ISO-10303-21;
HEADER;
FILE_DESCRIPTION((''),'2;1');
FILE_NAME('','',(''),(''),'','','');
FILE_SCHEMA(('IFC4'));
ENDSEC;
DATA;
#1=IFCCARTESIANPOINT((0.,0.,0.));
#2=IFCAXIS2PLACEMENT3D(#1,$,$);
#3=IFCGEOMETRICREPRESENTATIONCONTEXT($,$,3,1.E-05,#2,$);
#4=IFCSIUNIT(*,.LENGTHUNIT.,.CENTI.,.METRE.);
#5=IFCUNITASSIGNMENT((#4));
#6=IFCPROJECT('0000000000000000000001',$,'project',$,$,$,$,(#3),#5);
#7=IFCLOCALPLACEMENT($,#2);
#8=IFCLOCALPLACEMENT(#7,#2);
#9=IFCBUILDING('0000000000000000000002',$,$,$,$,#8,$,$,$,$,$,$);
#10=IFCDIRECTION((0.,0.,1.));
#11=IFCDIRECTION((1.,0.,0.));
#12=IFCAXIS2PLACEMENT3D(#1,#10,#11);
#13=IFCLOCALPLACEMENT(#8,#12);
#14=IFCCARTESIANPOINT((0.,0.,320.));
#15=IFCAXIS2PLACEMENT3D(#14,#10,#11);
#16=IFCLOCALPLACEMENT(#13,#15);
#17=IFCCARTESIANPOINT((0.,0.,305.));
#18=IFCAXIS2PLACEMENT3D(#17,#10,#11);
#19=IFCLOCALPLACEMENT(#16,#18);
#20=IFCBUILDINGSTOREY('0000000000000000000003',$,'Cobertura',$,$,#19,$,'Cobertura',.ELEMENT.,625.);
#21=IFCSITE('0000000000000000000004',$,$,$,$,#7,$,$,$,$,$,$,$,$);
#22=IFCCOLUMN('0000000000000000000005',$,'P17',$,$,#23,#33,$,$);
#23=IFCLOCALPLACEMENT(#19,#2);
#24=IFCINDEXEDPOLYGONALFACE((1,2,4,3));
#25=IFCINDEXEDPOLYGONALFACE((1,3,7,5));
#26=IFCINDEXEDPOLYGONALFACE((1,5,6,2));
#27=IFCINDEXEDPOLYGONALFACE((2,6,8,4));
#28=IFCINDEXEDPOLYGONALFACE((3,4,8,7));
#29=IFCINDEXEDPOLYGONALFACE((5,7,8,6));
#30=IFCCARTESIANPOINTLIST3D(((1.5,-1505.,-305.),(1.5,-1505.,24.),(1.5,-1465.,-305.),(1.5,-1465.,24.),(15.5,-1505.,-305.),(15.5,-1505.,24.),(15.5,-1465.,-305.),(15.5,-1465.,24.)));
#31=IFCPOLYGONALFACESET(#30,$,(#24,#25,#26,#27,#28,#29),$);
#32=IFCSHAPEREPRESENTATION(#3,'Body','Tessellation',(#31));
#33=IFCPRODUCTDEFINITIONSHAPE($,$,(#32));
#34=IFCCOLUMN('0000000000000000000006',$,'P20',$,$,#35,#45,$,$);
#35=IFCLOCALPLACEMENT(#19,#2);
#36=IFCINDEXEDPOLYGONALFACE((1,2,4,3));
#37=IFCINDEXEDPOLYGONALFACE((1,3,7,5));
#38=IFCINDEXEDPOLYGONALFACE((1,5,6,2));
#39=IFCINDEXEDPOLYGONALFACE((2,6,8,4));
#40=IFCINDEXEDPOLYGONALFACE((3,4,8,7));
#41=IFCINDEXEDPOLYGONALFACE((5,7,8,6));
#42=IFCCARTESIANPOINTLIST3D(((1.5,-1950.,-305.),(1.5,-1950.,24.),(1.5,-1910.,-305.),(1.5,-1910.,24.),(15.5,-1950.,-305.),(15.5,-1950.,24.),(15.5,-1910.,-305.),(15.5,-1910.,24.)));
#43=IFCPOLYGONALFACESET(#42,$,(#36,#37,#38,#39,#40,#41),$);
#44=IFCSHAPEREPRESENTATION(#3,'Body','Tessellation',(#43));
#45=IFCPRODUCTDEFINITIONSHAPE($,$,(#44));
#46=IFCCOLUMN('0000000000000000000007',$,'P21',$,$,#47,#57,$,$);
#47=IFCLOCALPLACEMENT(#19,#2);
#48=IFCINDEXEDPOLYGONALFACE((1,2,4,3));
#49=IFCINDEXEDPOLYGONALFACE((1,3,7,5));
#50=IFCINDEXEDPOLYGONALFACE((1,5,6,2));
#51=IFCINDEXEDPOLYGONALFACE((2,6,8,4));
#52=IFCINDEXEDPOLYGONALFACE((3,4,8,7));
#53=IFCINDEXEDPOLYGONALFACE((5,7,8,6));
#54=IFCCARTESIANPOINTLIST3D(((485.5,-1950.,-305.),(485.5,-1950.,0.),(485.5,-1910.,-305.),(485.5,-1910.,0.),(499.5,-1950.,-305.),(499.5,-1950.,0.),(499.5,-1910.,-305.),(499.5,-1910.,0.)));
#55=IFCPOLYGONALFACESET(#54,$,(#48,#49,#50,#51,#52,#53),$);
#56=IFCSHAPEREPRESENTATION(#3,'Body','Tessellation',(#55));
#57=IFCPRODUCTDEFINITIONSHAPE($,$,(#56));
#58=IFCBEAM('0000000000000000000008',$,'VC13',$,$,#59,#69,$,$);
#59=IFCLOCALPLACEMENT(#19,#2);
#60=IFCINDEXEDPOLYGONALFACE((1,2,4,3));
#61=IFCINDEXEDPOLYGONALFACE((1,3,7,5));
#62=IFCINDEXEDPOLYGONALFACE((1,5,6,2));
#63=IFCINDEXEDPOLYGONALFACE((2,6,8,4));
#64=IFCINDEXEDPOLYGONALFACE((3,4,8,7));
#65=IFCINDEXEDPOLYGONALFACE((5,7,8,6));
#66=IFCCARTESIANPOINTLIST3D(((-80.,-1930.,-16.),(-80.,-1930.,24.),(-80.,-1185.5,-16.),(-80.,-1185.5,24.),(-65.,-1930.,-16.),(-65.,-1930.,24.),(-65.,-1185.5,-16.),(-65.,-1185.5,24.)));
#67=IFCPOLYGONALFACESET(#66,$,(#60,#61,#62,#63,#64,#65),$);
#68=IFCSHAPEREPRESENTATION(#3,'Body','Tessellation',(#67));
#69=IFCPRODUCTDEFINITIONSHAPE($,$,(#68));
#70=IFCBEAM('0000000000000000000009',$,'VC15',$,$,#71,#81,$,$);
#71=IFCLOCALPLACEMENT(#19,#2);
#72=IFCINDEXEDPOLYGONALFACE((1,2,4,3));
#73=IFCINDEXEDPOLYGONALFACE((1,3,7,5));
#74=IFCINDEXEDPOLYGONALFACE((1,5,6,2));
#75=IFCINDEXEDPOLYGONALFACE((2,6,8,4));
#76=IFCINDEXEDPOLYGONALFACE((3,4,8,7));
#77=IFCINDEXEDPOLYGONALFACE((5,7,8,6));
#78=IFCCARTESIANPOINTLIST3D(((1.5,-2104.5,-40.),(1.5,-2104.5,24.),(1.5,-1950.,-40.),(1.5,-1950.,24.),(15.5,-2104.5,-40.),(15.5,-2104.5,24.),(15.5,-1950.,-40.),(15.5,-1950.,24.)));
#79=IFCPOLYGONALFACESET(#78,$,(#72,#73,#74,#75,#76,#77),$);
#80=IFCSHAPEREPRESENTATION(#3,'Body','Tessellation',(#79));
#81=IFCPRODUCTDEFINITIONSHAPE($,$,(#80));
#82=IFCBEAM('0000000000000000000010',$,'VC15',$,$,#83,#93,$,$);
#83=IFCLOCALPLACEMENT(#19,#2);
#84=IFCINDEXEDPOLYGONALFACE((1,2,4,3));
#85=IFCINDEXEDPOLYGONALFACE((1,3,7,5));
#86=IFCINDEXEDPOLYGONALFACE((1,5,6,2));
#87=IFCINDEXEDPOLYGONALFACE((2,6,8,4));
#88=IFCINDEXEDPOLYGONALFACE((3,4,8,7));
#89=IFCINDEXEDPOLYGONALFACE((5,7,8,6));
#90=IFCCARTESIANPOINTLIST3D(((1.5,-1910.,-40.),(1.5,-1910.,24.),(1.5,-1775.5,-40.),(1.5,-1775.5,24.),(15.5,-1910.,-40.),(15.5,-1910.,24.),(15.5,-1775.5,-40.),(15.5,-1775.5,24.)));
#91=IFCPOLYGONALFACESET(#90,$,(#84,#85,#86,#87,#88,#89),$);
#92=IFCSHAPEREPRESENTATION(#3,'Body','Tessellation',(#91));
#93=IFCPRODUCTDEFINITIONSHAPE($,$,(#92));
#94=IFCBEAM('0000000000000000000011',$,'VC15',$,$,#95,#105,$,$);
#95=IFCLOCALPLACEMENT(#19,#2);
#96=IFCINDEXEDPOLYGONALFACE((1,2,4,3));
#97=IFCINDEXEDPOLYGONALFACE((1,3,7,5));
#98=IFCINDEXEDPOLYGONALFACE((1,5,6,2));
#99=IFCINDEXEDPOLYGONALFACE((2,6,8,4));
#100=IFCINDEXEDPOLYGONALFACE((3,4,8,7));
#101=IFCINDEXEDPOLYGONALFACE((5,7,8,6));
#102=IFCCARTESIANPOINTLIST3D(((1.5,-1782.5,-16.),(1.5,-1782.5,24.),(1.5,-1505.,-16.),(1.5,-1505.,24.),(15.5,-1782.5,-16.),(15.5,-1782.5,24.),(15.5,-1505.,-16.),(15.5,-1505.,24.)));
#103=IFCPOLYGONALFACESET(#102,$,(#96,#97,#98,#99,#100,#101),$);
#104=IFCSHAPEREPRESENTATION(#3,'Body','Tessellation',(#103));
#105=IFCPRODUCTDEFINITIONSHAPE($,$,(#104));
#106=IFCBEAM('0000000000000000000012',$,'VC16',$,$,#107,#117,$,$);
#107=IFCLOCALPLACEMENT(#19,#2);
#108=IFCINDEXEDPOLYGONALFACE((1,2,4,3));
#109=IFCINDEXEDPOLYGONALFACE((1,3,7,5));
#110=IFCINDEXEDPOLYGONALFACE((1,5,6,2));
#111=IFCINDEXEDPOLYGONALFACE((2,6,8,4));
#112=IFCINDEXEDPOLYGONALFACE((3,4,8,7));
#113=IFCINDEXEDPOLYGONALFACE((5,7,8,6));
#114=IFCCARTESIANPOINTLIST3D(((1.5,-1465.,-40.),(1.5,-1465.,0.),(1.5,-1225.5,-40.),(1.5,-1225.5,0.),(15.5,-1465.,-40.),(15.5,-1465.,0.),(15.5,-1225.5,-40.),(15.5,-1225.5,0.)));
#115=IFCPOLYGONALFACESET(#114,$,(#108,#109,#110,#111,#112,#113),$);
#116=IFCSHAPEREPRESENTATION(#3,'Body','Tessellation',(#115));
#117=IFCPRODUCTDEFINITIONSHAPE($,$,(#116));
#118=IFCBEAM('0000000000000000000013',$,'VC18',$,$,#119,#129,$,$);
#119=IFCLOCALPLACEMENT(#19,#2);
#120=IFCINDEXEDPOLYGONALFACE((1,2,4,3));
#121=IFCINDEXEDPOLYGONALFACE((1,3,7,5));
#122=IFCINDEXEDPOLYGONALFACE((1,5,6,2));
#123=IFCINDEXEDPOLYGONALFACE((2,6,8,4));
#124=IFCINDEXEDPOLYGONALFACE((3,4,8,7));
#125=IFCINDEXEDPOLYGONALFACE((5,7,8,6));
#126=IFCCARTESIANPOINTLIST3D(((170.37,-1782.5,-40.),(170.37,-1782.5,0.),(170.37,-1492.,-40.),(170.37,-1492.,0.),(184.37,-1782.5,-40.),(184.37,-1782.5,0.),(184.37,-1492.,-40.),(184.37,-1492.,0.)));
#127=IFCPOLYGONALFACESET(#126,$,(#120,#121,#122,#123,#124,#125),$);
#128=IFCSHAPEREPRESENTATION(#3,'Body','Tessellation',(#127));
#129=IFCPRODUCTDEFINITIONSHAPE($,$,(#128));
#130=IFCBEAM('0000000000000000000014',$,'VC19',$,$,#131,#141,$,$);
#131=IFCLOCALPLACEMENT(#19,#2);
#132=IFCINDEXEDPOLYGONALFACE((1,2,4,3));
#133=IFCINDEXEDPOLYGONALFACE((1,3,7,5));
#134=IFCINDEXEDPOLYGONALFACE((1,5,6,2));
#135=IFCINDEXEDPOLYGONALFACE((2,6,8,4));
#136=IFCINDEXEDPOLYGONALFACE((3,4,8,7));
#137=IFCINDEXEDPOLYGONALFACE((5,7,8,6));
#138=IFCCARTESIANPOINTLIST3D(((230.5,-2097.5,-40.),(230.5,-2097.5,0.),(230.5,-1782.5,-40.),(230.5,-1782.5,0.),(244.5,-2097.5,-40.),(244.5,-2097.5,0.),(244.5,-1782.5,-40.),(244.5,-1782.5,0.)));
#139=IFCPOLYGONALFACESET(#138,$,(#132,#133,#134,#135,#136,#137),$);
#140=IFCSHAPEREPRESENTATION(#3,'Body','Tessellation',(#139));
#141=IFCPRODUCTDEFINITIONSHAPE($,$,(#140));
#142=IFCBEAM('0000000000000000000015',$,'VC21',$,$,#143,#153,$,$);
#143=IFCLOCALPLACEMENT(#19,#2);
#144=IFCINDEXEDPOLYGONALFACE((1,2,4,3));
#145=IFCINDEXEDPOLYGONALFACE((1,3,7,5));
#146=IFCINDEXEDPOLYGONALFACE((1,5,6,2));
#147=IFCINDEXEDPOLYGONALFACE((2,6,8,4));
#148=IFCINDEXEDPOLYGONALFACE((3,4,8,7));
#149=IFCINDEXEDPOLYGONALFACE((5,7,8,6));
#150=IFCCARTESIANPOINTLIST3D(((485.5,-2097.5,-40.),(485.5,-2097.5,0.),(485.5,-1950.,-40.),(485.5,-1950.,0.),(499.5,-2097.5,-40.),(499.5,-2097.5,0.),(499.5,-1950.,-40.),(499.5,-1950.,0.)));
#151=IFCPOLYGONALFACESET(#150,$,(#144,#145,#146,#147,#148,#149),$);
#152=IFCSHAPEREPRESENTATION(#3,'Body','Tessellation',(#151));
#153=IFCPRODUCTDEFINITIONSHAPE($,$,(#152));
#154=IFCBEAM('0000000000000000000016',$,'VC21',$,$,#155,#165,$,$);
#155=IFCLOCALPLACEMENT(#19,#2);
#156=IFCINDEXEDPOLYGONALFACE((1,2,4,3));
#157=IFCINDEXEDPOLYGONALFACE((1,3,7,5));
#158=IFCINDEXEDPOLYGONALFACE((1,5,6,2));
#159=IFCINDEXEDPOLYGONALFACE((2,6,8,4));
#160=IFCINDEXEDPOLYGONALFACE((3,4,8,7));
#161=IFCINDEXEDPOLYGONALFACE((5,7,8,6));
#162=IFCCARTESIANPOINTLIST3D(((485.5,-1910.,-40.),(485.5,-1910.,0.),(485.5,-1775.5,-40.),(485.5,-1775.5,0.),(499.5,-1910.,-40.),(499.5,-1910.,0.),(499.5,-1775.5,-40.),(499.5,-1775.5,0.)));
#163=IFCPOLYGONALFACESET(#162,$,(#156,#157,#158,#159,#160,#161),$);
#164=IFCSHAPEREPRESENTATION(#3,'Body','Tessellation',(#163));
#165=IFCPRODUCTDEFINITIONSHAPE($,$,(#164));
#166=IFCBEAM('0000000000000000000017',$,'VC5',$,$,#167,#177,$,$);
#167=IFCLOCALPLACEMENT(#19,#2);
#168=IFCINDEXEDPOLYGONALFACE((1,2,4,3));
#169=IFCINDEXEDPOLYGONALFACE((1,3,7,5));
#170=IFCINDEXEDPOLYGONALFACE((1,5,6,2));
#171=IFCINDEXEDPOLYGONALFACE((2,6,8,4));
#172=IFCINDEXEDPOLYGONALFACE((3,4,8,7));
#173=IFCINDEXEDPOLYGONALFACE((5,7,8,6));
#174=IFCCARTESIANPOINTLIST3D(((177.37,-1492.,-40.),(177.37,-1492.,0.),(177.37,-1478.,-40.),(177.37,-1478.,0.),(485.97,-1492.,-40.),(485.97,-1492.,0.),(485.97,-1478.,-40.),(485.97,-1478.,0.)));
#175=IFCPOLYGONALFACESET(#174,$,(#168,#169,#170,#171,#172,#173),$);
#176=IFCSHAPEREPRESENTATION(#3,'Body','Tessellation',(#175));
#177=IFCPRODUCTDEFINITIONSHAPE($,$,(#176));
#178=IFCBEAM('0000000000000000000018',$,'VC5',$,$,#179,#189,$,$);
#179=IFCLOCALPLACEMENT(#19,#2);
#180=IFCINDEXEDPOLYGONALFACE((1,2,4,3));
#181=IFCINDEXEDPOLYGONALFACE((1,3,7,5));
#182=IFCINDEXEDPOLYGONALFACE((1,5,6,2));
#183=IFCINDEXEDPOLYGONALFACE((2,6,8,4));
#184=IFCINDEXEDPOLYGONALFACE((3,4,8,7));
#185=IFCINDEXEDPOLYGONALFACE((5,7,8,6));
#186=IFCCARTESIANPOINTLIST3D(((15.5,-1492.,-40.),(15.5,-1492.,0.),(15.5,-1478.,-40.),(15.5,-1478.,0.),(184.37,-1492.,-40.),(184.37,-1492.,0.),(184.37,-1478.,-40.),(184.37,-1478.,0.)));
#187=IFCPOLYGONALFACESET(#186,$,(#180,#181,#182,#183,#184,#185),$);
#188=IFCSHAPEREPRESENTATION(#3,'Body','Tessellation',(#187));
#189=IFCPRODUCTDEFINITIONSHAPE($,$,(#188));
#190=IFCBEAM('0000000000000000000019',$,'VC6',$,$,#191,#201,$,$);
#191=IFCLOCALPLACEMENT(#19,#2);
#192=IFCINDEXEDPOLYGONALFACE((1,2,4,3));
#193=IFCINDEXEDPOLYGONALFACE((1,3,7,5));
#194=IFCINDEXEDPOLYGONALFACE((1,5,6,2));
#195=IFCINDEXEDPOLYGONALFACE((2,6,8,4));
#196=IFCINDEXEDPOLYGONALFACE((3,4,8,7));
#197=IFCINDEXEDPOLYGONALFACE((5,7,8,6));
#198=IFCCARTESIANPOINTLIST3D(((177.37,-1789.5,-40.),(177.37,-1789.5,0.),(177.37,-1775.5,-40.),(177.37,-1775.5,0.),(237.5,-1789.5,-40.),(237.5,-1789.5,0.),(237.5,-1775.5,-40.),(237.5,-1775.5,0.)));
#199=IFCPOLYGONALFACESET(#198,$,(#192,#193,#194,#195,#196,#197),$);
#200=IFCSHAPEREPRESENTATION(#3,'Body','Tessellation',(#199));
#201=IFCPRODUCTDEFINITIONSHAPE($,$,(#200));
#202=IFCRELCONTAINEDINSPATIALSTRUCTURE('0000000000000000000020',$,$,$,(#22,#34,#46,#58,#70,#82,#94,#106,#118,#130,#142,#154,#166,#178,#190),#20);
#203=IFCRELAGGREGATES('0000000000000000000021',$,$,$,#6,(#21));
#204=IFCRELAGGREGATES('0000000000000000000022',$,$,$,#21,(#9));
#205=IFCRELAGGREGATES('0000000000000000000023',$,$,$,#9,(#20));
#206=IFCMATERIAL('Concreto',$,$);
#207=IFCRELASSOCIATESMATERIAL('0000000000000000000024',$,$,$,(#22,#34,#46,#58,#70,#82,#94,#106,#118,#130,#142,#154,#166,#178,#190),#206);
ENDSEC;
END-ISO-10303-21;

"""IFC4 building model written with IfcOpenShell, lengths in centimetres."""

from ifc_helpers import new_model, si_unit, frame, origin, origin_with_axes, place, context, project, spatial, polyline, outline, extrude, material, element, save


model = new_model("IFC4")

# Units and contexts
context_of_model = context(None, 3, precision=1e-05, world=origin())
ifc_project = project(units=[si_unit("LENGTHUNIT", "METRE", prefix="CENTI")], contexts=[context_of_model])

# Site, building, storey
site_placement = place(None, origin())
site = spatial("IfcSite", under=ifc_project, at=site_placement)
building_placement = place(site_placement, origin())
building = spatial("IfcBuilding", under=site, at=building_placement)
placement_1 = place(building_placement, origin_with_axes())
placement_2 = place(placement_1, frame((0.0, 0.0, 320.0), z_axis=(0.0, 0.0, 1.0), x_axis=(1.0, 0.0, 0.0)))
storey_placement = place(placement_2, frame((0.0, 0.0, 305.0), z_axis=(0.0, 0.0, 1.0), x_axis=(1.0, 0.0, 0.0)))
storey = spatial("IfcBuildingStorey", under=building, at=storey_placement, Name="Cobertura", LongName="Cobertura", CompositionType="ELEMENT", Elevation=625.0)

# Columns
ifc_material = material(Name="Concreto")
for number, where, z_axis, x_axis, name in (
    (1, (8.5, -1485.0, 24.0), (0.0, 0.0, 1.0), (1.0, 0.0, 0.0), "P17"),
    (2, (8.5, -1930.0, 24.0), (0.0, 0.0, 1.0), (1.0, 0.0, 0.0), "P20"),
):
    element("IfcColumn", number, at=place(storey_placement, frame(where, z_axis=z_axis, x_axis=x_axis)), inside=storey, material=ifc_material, Name=name, context=context_of_model, shape_type="SolidModel", body=[
        extrude(outline(polyline([(-7.0, -20.0), (7.0, -20.0), (7.0, 20.0), (-7.0, 20.0), (-7.0, -20.0)])), frame((0.0, 0.0, 0.0), z_axis=(0.0, 0.0, 1.0), x_axis=(1.0, 0.0, 0.0)), (0.0, 0.0, -1.0), 329.0),
    ])
column_placement = place(storey_placement, frame((492.5, -1930.0, 0.0), z_axis=(0.0, 0.0, 1.0), x_axis=(1.0, 0.0, 0.0)))
element("IfcColumn", 3, at=column_placement, inside=storey, material=ifc_material, Name="P21", context=context_of_model, shape_type="SolidModel", body=[
    extrude(outline(polyline([(-7.0, -20.0), (7.0, -20.0), (7.0, 20.0), (-7.0, 20.0), (-7.0, -20.0)])), origin_with_axes(), (0.0, 0.0, -1.0), 305.0),
])

# Beams
beam_1_placement = place(storey_placement, frame((-72.5, -1557.75, 24.0), z_axis=(0.0, 0.0, 1.0), x_axis=(1.0, 0.0, 0.0)))
element("IfcBeam", 4, at=beam_1_placement, inside=storey, material=ifc_material, Name="VC13", context=context_of_model, shape_type="SolidModel", body=[
    extrude(outline(polyline([(-7.5, -20.0), (7.5, -20.0), (7.5, 20.0), (-7.5, 20.0), (-7.5, -20.0)])), frame((0.0, -372.25, -20.0), z_axis=(0.0, 1.0, 0.0), x_axis=(1.0, 0.0, 0.0)), (0.0, 0.0, 1.0), 744.5),
])
beam_2_placement = place(storey_placement, frame((8.5, -2027.25, 24.0), z_axis=(0.0, 0.0, 1.0), x_axis=(1.0, 0.0, 0.0)))
element("IfcBeam", 5, at=beam_2_placement, inside=storey, material=ifc_material, Name="VC15", context=context_of_model, shape_type="SolidModel", body=[
    extrude(outline(polyline([(-7.0, -32.0), (7.0, -32.0), (7.0, 32.0), (-7.0, 32.0), (-7.0, -32.0)])), frame((0.0, -77.25, -32.0), z_axis=(0.0, 1.0, 0.0), x_axis=(1.0, 0.0, 0.0)), (0.0, 0.0, 1.0), 154.5),
])
beam_3_placement = place(storey_placement, frame((8.5, -1842.75, 24.0), z_axis=(0.0, 0.0, 1.0), x_axis=(1.0, 0.0, 0.0)))
element("IfcBeam", 6, at=beam_3_placement, inside=storey, material=ifc_material, Name="VC15", context=context_of_model, shape_type="SolidModel", body=[
    extrude(outline(polyline([(-7.0, -32.0), (7.0, -32.0), (7.0, 32.0), (-7.0, 32.0), (-7.0, -32.0)])), frame((0.0, -67.25, -32.0), z_axis=(0.0, 1.0, 0.0), x_axis=(1.0, 0.0, 0.0)), (0.0, 0.0, 1.0), 134.5),
])
beam_4_placement = place(storey_placement, frame((8.5, -1643.75, 24.0), z_axis=(0.0, 0.0, 1.0), x_axis=(1.0, 0.0, 0.0)))
element("IfcBeam", 7, at=beam_4_placement, inside=storey, material=ifc_material, Name="VC15", context=context_of_model, shape_type="SolidModel", body=[
    extrude(outline(polyline([(-7.0, -20.0), (7.0, -20.0), (7.0, 20.0), (-7.0, 20.0), (-7.0, -20.0)])), frame((0.0, -138.75, -20.0), z_axis=(0.0, 1.0, 0.0), x_axis=(1.0, 0.0, 0.0)), (0.0, 0.0, 1.0), 277.5),
])
beam_5_placement = place(storey_placement, frame((8.5, -1345.25, 0.0), z_axis=(0.0, 0.0, 1.0), x_axis=(1.0, 0.0, 0.0)))
element("IfcBeam", 8, at=beam_5_placement, inside=storey, material=ifc_material, Name="VC16", context=context_of_model, shape_type="SolidModel", body=[
    extrude(outline(polyline([(-7.0, -20.0), (7.0, -20.0), (7.0, 20.0), (-7.0, 20.0), (-7.0, -20.0)])), frame((0.0, -119.75, -20.0), z_axis=(0.0, 1.0, 0.0), x_axis=(1.0, 0.0, 0.0)), (0.0, 0.0, 1.0), 239.5),
])
beam_6_placement = place(storey_placement, frame((177.37, -1637.25, 0.0), z_axis=(0.0, 0.0, 1.0), x_axis=(1.0, 0.0, 0.0)))
element("IfcBeam", 9, at=beam_6_placement, inside=storey, material=ifc_material, Name="VC18", context=context_of_model, shape_type="SolidModel", body=[
    extrude(outline(polyline([(-7.0, -20.0), (7.0, -20.0), (7.0, 20.0), (-7.0, 20.0), (-7.0, -20.0)])), frame((0.0, -145.25, -20.0), z_axis=(0.0, 1.0, 0.0), x_axis=(1.0, 0.0, 0.0)), (0.0, 0.0, 1.0), 290.5),
])
beam_7_placement = place(storey_placement, frame((237.5, -1940.0, 0.0), z_axis=(0.0, 0.0, 1.0), x_axis=(1.0, 0.0, 0.0)))
element("IfcBeam", 10, at=beam_7_placement, inside=storey, material=ifc_material, Name="VC19", context=context_of_model, shape_type="SolidModel", body=[
    extrude(outline(polyline([(-7.0, -20.0), (7.0, -20.0), (7.0, 20.0), (-7.0, 20.0), (-7.0, -20.0)])), frame((0.0, -157.5, -20.0), z_axis=(0.0, 1.0, 0.0), x_axis=(1.0, 0.0, 0.0)), (0.0, 0.0, 1.0), 315.0),
])
beam_8_placement = place(storey_placement, frame((492.5, -2023.75, 0.0), z_axis=(0.0, 0.0, 1.0), x_axis=(1.0, 0.0, 0.0)))
element("IfcBeam", 11, at=beam_8_placement, inside=storey, material=ifc_material, Name="VC21", context=context_of_model, shape_type="SolidModel", body=[
    extrude(outline(polyline([(-7.0, -20.0), (7.0, -20.0), (7.0, 20.0), (-7.0, 20.0), (-7.0, -20.0)])), frame((0.0, -73.75, -20.0), z_axis=(0.0, 1.0, 0.0), x_axis=(1.0, 0.0, 0.0)), (0.0, 0.0, 1.0), 147.5),
])
beam_9_placement = place(storey_placement, frame((492.5, -1842.75, 0.0), z_axis=(0.0, 0.0, 1.0), x_axis=(1.0, 0.0, 0.0)))
element("IfcBeam", 12, at=beam_9_placement, inside=storey, material=ifc_material, Name="VC21", context=context_of_model, shape_type="SolidModel", body=[
    extrude(outline(polyline([(-7.0, -20.0), (7.0, -20.0), (7.0, 20.0), (-7.0, 20.0), (-7.0, -20.0)])), frame((0.0, -67.25, -20.0), z_axis=(0.0, 1.0, 0.0), x_axis=(1.0, 0.0, 0.0)), (0.0, 0.0, 1.0), 134.5),
])
beam_10_placement = place(storey_placement, frame((331.67, -1485.0, 0.0), z_axis=(0.0, 0.0, 1.0), x_axis=(1.0, 0.0, 0.0)))
element("IfcBeam", 13, at=beam_10_placement, inside=storey, material=ifc_material, Name="VC5", context=context_of_model, shape_type="SolidModel", body=[
    extrude(outline(polyline([(-7.0, -20.0), (7.0, -20.0), (7.0, 20.0), (-7.0, 20.0), (-7.0, -20.0)])), frame((-154.3, 0.0, -20.0), z_axis=(1.0, 0.0, 0.0), x_axis=(0.0, -1.0, 0.0)), (0.0, 0.0, 1.0), 308.6),
])
beam_11_placement = place(storey_placement, frame((99.94, -1485.0, 0.0), z_axis=(0.0, 0.0, 1.0), x_axis=(1.0, 0.0, 0.0)))
element("IfcBeam", 14, at=beam_11_placement, inside=storey, material=ifc_material, Name="VC5", context=context_of_model, shape_type="SolidModel", body=[
    extrude(outline(polyline([(-7.0, -20.0), (7.0, -20.0), (7.0, 20.0), (-7.0, 20.0), (-7.0, -20.0)])), frame((-84.44, 0.0, -20.0), z_axis=(1.0, 0.0, 0.0), x_axis=(0.0, -1.0, 0.0)), (0.0, 0.0, 1.0), 168.87),
])
beam_12_placement = place(storey_placement, frame((207.44, -1782.5, 0.0), z_axis=(0.0, 0.0, 1.0), x_axis=(1.0, 0.0, 0.0)))
element("IfcBeam", 15, at=beam_12_placement, inside=storey, material=ifc_material, Name="VC6", context=context_of_model, shape_type="SolidModel", body=[
    extrude(outline(polyline([(-7.0, -20.0), (7.0, -20.0), (7.0, 20.0), (-7.0, 20.0), (-7.0, -20.0)])), frame((-30.07, 0.0, -20.0), z_axis=(1.0, 0.0, 0.0), x_axis=(0.0, -1.0, 0.0)), (0.0, 0.0, 1.0), 60.13),
])

save(model, "model.ifc")
